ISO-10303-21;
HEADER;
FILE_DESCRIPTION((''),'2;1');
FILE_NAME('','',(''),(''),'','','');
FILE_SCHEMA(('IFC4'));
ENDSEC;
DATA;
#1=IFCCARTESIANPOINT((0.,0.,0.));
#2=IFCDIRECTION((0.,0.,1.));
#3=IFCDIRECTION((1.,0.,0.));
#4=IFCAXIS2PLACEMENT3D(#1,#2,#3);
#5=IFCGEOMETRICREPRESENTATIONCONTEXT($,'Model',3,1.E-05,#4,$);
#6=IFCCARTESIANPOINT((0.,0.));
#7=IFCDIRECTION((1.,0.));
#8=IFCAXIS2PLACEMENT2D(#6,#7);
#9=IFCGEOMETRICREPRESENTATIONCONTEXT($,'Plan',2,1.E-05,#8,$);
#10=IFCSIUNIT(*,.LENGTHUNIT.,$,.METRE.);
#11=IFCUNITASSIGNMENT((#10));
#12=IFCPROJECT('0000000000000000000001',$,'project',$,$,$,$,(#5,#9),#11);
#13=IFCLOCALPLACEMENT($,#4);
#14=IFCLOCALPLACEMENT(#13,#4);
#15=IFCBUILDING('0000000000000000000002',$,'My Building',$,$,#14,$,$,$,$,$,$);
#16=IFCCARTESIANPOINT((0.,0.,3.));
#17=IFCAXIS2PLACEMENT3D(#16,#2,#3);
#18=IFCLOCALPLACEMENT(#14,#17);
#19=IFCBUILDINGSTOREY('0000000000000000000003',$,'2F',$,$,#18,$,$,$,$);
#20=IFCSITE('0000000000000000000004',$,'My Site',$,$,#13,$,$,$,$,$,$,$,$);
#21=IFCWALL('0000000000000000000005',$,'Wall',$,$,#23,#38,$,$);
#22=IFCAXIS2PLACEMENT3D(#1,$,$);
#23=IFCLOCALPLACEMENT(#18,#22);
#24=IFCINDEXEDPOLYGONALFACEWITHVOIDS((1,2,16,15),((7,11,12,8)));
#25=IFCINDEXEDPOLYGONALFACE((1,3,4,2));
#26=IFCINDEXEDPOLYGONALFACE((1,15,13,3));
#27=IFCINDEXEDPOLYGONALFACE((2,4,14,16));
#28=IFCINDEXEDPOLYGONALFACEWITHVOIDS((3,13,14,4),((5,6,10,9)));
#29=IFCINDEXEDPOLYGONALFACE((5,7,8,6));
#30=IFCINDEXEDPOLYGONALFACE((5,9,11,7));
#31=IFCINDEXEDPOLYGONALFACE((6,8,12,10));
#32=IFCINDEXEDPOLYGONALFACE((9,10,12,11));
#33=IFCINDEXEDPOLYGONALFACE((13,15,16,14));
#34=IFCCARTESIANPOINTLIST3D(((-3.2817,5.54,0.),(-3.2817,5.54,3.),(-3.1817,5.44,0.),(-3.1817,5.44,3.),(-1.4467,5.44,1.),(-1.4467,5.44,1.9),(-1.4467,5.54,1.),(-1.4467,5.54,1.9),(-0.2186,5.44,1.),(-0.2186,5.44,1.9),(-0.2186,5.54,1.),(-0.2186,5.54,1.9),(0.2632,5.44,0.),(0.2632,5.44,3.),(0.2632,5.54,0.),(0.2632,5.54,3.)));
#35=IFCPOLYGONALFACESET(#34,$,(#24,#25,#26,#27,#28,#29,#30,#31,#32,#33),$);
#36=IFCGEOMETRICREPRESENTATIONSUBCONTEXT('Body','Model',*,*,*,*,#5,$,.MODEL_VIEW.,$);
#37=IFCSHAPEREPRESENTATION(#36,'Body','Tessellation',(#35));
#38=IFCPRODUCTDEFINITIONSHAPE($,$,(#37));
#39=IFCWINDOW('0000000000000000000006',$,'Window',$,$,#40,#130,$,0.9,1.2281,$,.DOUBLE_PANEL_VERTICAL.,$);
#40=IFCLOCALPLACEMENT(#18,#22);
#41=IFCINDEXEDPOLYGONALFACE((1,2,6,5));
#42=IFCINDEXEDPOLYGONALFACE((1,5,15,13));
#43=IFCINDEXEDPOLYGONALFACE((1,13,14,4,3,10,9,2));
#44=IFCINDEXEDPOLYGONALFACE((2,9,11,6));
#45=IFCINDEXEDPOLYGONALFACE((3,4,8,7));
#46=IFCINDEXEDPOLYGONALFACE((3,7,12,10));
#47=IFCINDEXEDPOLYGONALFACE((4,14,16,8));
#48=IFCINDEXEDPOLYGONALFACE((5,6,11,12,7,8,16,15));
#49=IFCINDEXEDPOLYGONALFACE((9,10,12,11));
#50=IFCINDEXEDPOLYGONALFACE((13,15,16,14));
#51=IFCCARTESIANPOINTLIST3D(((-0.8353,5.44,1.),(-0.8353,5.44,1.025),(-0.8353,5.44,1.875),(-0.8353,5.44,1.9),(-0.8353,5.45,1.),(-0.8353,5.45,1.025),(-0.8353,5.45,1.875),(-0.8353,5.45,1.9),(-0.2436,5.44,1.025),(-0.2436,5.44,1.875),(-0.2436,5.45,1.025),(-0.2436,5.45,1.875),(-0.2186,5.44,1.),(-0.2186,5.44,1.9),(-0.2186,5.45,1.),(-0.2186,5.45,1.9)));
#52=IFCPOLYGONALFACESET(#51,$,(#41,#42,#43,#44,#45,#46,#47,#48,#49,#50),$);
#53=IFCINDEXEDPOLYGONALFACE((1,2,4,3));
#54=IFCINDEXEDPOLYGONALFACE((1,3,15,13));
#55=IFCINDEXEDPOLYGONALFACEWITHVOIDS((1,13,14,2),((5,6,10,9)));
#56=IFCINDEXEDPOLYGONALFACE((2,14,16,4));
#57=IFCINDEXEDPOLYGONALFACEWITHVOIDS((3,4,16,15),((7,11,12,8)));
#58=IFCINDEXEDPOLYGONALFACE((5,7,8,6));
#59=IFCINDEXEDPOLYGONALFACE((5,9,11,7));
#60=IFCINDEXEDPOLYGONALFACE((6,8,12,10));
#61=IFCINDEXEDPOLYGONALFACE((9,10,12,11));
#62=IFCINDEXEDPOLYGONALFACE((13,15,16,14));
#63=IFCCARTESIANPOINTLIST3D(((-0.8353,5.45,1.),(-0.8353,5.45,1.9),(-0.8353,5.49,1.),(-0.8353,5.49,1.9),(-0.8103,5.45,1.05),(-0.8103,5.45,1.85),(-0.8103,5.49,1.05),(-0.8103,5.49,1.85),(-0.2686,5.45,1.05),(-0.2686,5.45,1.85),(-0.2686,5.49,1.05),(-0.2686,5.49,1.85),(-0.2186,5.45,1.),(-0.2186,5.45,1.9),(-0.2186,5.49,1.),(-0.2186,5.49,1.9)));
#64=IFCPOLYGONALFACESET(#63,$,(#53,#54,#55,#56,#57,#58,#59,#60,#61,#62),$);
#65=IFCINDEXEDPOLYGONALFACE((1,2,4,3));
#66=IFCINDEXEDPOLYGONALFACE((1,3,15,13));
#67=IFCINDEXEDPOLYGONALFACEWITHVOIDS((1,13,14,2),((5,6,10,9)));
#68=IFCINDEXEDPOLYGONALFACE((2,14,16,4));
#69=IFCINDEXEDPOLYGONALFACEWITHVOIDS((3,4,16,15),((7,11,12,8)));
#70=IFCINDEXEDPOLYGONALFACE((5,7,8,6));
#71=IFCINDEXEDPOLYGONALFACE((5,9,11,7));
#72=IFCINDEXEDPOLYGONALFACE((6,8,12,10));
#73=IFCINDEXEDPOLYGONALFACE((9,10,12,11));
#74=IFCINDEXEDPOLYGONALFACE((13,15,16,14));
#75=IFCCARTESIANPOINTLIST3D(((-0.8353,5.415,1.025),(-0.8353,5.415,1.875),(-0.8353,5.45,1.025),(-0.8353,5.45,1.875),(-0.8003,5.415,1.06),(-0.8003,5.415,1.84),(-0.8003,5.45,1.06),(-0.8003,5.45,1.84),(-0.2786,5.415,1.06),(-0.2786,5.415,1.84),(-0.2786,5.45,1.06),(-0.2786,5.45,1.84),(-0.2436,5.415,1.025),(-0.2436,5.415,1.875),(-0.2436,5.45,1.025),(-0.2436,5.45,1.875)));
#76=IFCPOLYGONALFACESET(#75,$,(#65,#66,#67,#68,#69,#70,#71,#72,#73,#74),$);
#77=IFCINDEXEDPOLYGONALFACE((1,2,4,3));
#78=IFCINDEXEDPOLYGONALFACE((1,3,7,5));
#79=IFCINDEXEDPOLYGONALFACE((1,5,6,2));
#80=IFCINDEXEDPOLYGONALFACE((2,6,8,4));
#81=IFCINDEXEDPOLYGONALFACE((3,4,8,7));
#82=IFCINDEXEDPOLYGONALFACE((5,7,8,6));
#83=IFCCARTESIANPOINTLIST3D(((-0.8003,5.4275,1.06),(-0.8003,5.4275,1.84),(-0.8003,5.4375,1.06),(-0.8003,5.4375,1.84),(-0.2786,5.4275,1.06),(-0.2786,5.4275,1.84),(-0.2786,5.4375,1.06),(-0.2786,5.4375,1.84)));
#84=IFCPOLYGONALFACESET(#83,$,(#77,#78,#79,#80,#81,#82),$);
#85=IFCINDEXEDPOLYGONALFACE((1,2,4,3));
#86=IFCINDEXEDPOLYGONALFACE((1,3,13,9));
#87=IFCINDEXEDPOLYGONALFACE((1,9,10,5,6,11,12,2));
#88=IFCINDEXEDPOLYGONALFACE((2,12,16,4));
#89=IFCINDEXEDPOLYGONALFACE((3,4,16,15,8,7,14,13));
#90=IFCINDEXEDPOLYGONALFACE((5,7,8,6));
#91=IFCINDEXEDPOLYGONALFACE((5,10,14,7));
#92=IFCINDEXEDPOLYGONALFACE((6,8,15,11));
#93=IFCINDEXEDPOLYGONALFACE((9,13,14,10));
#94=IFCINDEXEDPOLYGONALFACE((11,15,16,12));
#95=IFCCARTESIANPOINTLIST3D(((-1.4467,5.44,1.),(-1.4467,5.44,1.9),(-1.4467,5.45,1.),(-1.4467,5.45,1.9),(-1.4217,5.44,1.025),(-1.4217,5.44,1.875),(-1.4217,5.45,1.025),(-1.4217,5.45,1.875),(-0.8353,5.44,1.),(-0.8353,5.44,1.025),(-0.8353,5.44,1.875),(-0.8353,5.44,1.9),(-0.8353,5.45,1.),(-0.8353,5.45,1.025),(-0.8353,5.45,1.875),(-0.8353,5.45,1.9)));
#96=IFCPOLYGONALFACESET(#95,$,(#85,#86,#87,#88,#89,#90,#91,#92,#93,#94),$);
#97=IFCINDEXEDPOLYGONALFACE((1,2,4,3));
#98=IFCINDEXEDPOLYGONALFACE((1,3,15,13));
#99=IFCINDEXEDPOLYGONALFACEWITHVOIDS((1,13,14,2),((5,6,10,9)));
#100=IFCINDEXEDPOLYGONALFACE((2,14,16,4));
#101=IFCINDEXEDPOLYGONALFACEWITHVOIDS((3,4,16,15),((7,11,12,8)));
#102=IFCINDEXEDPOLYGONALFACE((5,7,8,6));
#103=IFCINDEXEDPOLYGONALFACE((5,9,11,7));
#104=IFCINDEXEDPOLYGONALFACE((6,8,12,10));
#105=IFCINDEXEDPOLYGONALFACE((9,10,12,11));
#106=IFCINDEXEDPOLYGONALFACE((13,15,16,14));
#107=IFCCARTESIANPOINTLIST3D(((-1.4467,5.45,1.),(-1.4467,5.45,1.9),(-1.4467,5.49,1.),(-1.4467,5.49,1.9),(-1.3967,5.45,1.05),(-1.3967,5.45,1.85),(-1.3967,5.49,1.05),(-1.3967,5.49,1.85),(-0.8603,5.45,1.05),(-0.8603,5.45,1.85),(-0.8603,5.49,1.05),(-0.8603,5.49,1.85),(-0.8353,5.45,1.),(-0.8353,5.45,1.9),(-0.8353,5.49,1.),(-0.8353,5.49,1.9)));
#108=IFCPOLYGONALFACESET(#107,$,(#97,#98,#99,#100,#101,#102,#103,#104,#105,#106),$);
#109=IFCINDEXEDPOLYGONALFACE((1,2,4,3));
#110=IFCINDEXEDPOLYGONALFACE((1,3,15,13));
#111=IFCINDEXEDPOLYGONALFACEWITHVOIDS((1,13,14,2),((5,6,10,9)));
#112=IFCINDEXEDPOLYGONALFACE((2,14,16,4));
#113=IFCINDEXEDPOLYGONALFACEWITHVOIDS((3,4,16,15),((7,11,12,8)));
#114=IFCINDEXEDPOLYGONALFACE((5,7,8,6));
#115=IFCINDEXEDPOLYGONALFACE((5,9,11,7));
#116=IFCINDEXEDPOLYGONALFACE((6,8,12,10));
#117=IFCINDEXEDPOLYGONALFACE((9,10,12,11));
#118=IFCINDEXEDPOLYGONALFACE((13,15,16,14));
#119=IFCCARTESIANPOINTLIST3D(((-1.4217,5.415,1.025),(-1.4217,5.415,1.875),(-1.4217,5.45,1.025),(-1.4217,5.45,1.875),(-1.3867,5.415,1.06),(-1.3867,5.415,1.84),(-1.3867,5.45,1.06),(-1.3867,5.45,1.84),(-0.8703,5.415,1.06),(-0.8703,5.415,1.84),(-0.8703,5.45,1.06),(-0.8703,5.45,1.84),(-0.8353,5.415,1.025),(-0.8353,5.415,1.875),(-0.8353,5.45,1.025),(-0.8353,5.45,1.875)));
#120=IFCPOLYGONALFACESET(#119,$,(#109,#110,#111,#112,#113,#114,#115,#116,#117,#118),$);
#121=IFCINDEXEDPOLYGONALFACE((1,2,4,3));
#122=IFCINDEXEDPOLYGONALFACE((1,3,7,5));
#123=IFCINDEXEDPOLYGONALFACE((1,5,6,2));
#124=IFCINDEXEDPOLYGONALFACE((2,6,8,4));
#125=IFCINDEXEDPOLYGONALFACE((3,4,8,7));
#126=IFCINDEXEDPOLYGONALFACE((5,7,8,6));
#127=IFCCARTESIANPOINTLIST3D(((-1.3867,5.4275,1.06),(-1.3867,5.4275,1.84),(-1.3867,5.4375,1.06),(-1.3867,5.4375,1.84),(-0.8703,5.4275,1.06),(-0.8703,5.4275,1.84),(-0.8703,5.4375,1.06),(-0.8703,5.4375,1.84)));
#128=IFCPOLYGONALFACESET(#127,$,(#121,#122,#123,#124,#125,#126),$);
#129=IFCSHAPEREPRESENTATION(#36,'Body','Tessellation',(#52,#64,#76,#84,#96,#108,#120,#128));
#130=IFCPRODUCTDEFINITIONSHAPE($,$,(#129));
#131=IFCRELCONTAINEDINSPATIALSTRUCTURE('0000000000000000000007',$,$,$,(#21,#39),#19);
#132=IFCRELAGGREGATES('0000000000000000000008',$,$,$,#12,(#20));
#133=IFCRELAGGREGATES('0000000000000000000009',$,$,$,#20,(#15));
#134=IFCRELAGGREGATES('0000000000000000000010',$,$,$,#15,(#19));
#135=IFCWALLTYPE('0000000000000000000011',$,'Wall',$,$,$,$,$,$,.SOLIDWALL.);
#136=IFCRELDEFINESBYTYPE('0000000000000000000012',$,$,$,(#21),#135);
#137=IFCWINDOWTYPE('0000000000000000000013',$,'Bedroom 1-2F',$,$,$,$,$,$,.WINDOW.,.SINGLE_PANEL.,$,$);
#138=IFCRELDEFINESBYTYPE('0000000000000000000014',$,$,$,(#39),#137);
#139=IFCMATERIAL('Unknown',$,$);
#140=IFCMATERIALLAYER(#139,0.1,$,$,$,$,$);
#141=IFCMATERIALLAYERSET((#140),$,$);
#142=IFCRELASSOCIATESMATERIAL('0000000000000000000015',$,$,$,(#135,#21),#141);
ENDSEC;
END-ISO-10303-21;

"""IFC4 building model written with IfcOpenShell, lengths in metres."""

from ifc_helpers import new_model, entity, si_unit, frame, origin_with_axes, origin_2d_with_axis, place, context, subcontext, project, spatial, line, indexed_curve, outline, extrude, shape, source, transform, mapped, material, layer, layer_set, layer_usage, type_object, type_shapes, element, fill, save


model = new_model("IFC4")

# Units and contexts
model_context = context("Model", 3, precision=1e-05, world=origin_with_axes())
plan_context = context("Plan", 2, precision=1e-05, world=origin_2d_with_axis())
body_context_1 = subcontext(model_context, "Body", "Model", "MODEL_VIEW")
body_context_2 = subcontext(plan_context, "Body", "Plan", "PLAN_VIEW")
ifc_project = project(units=[si_unit("LENGTHUNIT", "METRE")], contexts=[model_context, plan_context])

# Site, building, storey
site_placement = place(None, origin_with_axes())
site = spatial("IfcSite", under=ifc_project, at=site_placement, Name="My Site")
building_placement = place(site_placement, origin_with_axes())
building = spatial("IfcBuilding", under=site, at=building_placement, Name="My Building")
storey_placement = place(building_placement, frame((0.0, 0.0, 3.0), z_axis=(0.0, 0.0, 1.0), x_axis=(1.0, 0.0, 0.0)))
storey = spatial("IfcBuildingStorey", under=building, at=storey_placement, Name="2F")

# Shared definitions
ifc_material = material(Name="Unknown")

# Shared definitions
ifc_layer_1 = layer(ifc_material, 0.1)
ifc_layer_set_1 = layer_set([ifc_layer_1])
wall_type = type_object("IfcWallType", Name="Wall", PredefinedType="SOLIDWALL", material=ifc_layer_set_1)

# Wall, opening, window
ifc_layer_usage_1 = layer_usage(ifc_layer_set_1, "AXIS2", "POSITIVE", 0.0)
wall_1_placement = place(storey_placement, frame((0.2632, 5.54, 0.0), z_axis=(0.0, 0.0, 1.0), x_axis=(-1.0, 0.0, 0.0)))
wall_1 = element("IfcWall", 1, at=wall_1_placement, inside=storey, type_object=wall_type, material=ifc_layer_usage_1, Name="Wall", context=body_context_1, shape_type="SweptSolid", body=[
    extrude(outline(indexed_curve([(0.0, 0.0), (0.0, 0.1), (3.4448, 0.1), (3.5448, 0.0)], segments=[line(1, 2, 3, 4, 1)])), origin_with_axes(), (0.0, 0.0, 1.0), 3.0),
])
shared_shape_1 = source(origin_with_axes(), body_context_1, "Body", "SweptSolid", [
    extrude(outline(indexed_curve([(0.0, 0.0), (1.2281, 0.0), (1.2281, 0.9), (0.0, 0.9)], segments=[line(1, 2, 3, 4, 1)])), frame((0.0, -0.6, 0.0), z_axis=(0.0, -1.0, 0.0), x_axis=(1.0, 0.0, 0.0)), (0.0, 0.0, -1.0), 1.2),
])
opening_1_placement = place(wall_1_placement, frame((0.4818, 0.0, 1.0), z_axis=(0.0, 0.0, 1.0), x_axis=(1.0, 0.0, 0.0)))
opening_1 = element("IfcOpeningElement", 2, at=opening_1_placement, cuts=wall_1, PredefinedType="OPENING", context=body_context_1, shape_type="MappedRepresentation", body=[
    mapped(shared_shape_1, transform((0.0, 0.0, 0.0), x_axis=(1.0, 0.0, 0.0), y_axis=(0.0, 1.0, 0.0), z_axis=(0.0, 0.0, 1.0), scale=1.0)),
])
window_type_1 = type_object("IfcWindowType", Name="Bedroom 1-2F", PartitioningType="SINGLE_PANEL", PredefinedType="WINDOW")
shared_shape_2 = source(origin_with_axes(), body_context_1, "Body", "SweptSolid", [
    extrude(outline(indexed_curve([(0.6167, 0.0), (0.0, 0.0), (0.0, 0.9), (0.6167, 0.9), (0.6167, 0.875), (0.025, 0.875), (0.025, 0.025), (0.6167, 0.025)], segments=[line(1, 2, 3, 4, 5, 6, 7, 8, 1)])), frame((0.0, 0.09, 0.0), z_axis=(0.0, -1.0, 0.0), x_axis=(1.0, 0.0, 0.0)), (0.0, 0.0, -1.0), 0.01),
    extrude(outline(indexed_curve([(0.0, 0.0), (0.6167, 0.0), (0.6167, 0.9), (0.0, 0.9)], segments=[line(1, 2, 3, 4, 1)]), holes=[indexed_curve([(0.05, 0.05), (0.5917, 0.05), (0.5917, 0.85), (0.05, 0.85)], segments=[line(1, 2, 3, 4, 1)])]), frame((0.0, 0.05, 0.0), z_axis=(0.0, -1.0, 0.0), x_axis=(1.0, 0.0, 0.0)), (0.0, 0.0, -1.0), 0.04),
    extrude(outline(indexed_curve([(0.0, 0.0), (0.5917, 0.0), (0.5917, 0.85), (0.0, 0.85)], segments=[line(1, 2, 3, 4, 1)]), holes=[indexed_curve([(0.035, 0.035), (0.5567, 0.035), (0.5567, 0.815), (0.035, 0.815)], segments=[line(1, 2, 3, 4, 1)])]), frame((0.025, 0.09, 0.025), z_axis=(0.0, -1.0, 0.0), x_axis=(1.0, 0.0, 0.0)), (0.0, 0.0, -1.0), 0.035),
    extrude(outline(indexed_curve([(0.035, 0.035), (0.5567, 0.035), (0.5567, 0.815), (0.035, 0.815)], segments=[line(1, 2, 3, 4, 1)])), frame((0.025, 0.1025, 0.025), z_axis=(0.0, -1.0, 0.0), x_axis=(1.0, 0.0, 0.0)), (0.0, 0.0, -1.0), 0.01),
    extrude(outline(indexed_curve([(0.0, 0.9), (0.6114, 0.9), (0.6114, 0.0), (0.0, 0.0), (0.0, 0.025), (0.5864, 0.025), (0.5864, 0.875), (0.0, 0.875)], segments=[line(1, 2, 3, 4, 5, 6, 7, 8, 1)])), frame((0.6167, 0.09, 0.0), z_axis=(0.0, -1.0, 0.0), x_axis=(1.0, 0.0, 0.0)), (0.0, 0.0, -1.0), 0.01),
    extrude(outline(indexed_curve([(0.0, 0.0), (0.6114, 0.0), (0.6114, 0.9), (0.0, 0.9)], segments=[line(1, 2, 3, 4, 1)]), holes=[indexed_curve([(0.025, 0.05), (0.5614, 0.05), (0.5614, 0.85), (0.025, 0.85)], segments=[line(1, 2, 3, 4, 1)])]), frame((0.6167, 0.05, 0.0), z_axis=(0.0, -1.0, 0.0), x_axis=(1.0, 0.0, 0.0)), (0.0, 0.0, -1.0), 0.04),
    extrude(outline(indexed_curve([(0.0, 0.0), (0.5864, 0.0), (0.5864, 0.85), (0.0, 0.85)], segments=[line(1, 2, 3, 4, 1)]), holes=[indexed_curve([(0.035, 0.035), (0.5514, 0.035), (0.5514, 0.815), (0.035, 0.815)], segments=[line(1, 2, 3, 4, 1)])]), frame((0.6167, 0.09, 0.025), z_axis=(0.0, -1.0, 0.0), x_axis=(1.0, 0.0, 0.0)), (0.0, 0.0, -1.0), 0.035),
    extrude(outline(indexed_curve([(0.035, 0.035), (0.5514, 0.035), (0.5514, 0.815), (0.035, 0.815)], segments=[line(1, 2, 3, 4, 1)])), frame((0.6167, 0.1025, 0.025), z_axis=(0.0, -1.0, 0.0), x_axis=(1.0, 0.0, 0.0)), (0.0, 0.0, -1.0), 0.01),
])
shared_shape_3 = source(origin_with_axes(), body_context_2, "Body", "Curve2D", [
    entity("IfcIndexedPolyCurve", entity("IfcCartesianPointList2D", [[0.05, 0.05], [0.5917, 0.05]])),
    entity("IfcIndexedPolyCurve", entity("IfcCartesianPointList2D", [[0.0, 0.1], [0.025, 0.1], [0.025, 0.09], [0.05, 0.09], [0.05, 0.05], [0.0, 0.05]]), [entity("IfcLineIndex", [1, 2, 3, 4, 5, 6, 1])]),
    entity("IfcIndexedPolyCurve", entity("IfcCartesianPointList2D", [[0.6167, 0.1], [0.6167, 0.1], [0.6167, 0.09], [0.5917, 0.09], [0.5917, 0.05], [0.6167, 0.05]])),
    entity("IfcIndexedPolyCurve", entity("IfcCartesianPointList2D", [[0.025, 0.09], [0.06, 0.09], [0.06, 0.125], [0.025, 0.125]]), [entity("IfcLineIndex", [1, 2, 3, 4, 1])]),
    entity("IfcIndexedPolyCurve", entity("IfcCartesianPointList2D", [[0.6167, 0.09], [0.5817, 0.09], [0.5817, 0.125], [0.6167, 0.125]]), [entity("IfcLineIndex", [1, 2, 3, 4, 1])]),
    entity("IfcIndexedPolyCurve", entity("IfcCartesianPointList2D", [[0.06, 0.09], [0.5817, 0.09]])),
    entity("IfcIndexedPolyCurve", entity("IfcCartesianPointList2D", [[0.06, 0.125], [0.5817, 0.125]])),
    entity("IfcIndexedPolyCurve", entity("IfcCartesianPointList2D", [[0.06, 0.1075], [0.5817, 0.1075]])),
    entity("IfcIndexedPolyCurve", entity("IfcCartesianPointList2D", [[0.6417, 0.05], [1.1781, 0.05]])),
    entity("IfcIndexedPolyCurve", entity("IfcCartesianPointList2D", [[0.6167, 0.1], [0.6167, 0.1], [0.6167, 0.09], [0.6417, 0.09], [0.6417, 0.05], [0.6167, 0.05]])),
    entity("IfcIndexedPolyCurve", entity("IfcCartesianPointList2D", [[1.2281, 0.1], [1.2031, 0.1], [1.2031, 0.09], [1.1781, 0.09], [1.1781, 0.05], [1.2281, 0.05]]), [entity("IfcLineIndex", [1, 2, 3, 4, 5, 6, 1])]),
    entity("IfcIndexedPolyCurve", entity("IfcCartesianPointList2D", [[0.6167, 0.09], [0.6517, 0.09], [0.6517, 0.125], [0.6167, 0.125]]), [entity("IfcLineIndex", [1, 2, 3, 4, 1])]),
    entity("IfcIndexedPolyCurve", entity("IfcCartesianPointList2D", [[1.2031, 0.09], [1.1681, 0.09], [1.1681, 0.125], [1.2031, 0.125]]), [entity("IfcLineIndex", [1, 2, 3, 4, 1])]),
    entity("IfcIndexedPolyCurve", entity("IfcCartesianPointList2D", [[0.6517, 0.09], [1.1681, 0.09]])),
    entity("IfcIndexedPolyCurve", entity("IfcCartesianPointList2D", [[0.6517, 0.125], [1.1681, 0.125]])),
    entity("IfcIndexedPolyCurve", entity("IfcCartesianPointList2D", [[0.6517, 0.1075], [1.1681, 0.1075]])),
])
type_shapes(window_type_1, [shared_shape_2, shared_shape_3])
window_1_placement = place(opening_1_placement, origin_with_axes())
window_1 = element("IfcWindow", 3, at=window_1_placement, inside=storey, type_object=window_type_1, Name="Window", OverallHeight=0.9, OverallWidth=1.2281, PartitioningType="DOUBLE_PANEL_VERTICAL", shapes=[
    shape(body_context_1, "Body", "MappedRepresentation", [mapped(shared_shape_2, transform((0.0, 0.0, 0.0), x_axis=(1.0, 0.0, 0.0), y_axis=(0.0, 1.0, 0.0), z_axis=(0.0, 0.0, 1.0), scale=1.0))]),
    shape(body_context_2, "Body", "MappedRepresentation", [mapped(shared_shape_3, transform((0.0, 0.0, 0.0), x_axis=(1.0, 0.0, 0.0), y_axis=(0.0, 1.0, 0.0), z_axis=(0.0, 0.0, 1.0), scale=1.0))]),
])
fill(opening_1, window_1)

save(model, "model.ifc")
